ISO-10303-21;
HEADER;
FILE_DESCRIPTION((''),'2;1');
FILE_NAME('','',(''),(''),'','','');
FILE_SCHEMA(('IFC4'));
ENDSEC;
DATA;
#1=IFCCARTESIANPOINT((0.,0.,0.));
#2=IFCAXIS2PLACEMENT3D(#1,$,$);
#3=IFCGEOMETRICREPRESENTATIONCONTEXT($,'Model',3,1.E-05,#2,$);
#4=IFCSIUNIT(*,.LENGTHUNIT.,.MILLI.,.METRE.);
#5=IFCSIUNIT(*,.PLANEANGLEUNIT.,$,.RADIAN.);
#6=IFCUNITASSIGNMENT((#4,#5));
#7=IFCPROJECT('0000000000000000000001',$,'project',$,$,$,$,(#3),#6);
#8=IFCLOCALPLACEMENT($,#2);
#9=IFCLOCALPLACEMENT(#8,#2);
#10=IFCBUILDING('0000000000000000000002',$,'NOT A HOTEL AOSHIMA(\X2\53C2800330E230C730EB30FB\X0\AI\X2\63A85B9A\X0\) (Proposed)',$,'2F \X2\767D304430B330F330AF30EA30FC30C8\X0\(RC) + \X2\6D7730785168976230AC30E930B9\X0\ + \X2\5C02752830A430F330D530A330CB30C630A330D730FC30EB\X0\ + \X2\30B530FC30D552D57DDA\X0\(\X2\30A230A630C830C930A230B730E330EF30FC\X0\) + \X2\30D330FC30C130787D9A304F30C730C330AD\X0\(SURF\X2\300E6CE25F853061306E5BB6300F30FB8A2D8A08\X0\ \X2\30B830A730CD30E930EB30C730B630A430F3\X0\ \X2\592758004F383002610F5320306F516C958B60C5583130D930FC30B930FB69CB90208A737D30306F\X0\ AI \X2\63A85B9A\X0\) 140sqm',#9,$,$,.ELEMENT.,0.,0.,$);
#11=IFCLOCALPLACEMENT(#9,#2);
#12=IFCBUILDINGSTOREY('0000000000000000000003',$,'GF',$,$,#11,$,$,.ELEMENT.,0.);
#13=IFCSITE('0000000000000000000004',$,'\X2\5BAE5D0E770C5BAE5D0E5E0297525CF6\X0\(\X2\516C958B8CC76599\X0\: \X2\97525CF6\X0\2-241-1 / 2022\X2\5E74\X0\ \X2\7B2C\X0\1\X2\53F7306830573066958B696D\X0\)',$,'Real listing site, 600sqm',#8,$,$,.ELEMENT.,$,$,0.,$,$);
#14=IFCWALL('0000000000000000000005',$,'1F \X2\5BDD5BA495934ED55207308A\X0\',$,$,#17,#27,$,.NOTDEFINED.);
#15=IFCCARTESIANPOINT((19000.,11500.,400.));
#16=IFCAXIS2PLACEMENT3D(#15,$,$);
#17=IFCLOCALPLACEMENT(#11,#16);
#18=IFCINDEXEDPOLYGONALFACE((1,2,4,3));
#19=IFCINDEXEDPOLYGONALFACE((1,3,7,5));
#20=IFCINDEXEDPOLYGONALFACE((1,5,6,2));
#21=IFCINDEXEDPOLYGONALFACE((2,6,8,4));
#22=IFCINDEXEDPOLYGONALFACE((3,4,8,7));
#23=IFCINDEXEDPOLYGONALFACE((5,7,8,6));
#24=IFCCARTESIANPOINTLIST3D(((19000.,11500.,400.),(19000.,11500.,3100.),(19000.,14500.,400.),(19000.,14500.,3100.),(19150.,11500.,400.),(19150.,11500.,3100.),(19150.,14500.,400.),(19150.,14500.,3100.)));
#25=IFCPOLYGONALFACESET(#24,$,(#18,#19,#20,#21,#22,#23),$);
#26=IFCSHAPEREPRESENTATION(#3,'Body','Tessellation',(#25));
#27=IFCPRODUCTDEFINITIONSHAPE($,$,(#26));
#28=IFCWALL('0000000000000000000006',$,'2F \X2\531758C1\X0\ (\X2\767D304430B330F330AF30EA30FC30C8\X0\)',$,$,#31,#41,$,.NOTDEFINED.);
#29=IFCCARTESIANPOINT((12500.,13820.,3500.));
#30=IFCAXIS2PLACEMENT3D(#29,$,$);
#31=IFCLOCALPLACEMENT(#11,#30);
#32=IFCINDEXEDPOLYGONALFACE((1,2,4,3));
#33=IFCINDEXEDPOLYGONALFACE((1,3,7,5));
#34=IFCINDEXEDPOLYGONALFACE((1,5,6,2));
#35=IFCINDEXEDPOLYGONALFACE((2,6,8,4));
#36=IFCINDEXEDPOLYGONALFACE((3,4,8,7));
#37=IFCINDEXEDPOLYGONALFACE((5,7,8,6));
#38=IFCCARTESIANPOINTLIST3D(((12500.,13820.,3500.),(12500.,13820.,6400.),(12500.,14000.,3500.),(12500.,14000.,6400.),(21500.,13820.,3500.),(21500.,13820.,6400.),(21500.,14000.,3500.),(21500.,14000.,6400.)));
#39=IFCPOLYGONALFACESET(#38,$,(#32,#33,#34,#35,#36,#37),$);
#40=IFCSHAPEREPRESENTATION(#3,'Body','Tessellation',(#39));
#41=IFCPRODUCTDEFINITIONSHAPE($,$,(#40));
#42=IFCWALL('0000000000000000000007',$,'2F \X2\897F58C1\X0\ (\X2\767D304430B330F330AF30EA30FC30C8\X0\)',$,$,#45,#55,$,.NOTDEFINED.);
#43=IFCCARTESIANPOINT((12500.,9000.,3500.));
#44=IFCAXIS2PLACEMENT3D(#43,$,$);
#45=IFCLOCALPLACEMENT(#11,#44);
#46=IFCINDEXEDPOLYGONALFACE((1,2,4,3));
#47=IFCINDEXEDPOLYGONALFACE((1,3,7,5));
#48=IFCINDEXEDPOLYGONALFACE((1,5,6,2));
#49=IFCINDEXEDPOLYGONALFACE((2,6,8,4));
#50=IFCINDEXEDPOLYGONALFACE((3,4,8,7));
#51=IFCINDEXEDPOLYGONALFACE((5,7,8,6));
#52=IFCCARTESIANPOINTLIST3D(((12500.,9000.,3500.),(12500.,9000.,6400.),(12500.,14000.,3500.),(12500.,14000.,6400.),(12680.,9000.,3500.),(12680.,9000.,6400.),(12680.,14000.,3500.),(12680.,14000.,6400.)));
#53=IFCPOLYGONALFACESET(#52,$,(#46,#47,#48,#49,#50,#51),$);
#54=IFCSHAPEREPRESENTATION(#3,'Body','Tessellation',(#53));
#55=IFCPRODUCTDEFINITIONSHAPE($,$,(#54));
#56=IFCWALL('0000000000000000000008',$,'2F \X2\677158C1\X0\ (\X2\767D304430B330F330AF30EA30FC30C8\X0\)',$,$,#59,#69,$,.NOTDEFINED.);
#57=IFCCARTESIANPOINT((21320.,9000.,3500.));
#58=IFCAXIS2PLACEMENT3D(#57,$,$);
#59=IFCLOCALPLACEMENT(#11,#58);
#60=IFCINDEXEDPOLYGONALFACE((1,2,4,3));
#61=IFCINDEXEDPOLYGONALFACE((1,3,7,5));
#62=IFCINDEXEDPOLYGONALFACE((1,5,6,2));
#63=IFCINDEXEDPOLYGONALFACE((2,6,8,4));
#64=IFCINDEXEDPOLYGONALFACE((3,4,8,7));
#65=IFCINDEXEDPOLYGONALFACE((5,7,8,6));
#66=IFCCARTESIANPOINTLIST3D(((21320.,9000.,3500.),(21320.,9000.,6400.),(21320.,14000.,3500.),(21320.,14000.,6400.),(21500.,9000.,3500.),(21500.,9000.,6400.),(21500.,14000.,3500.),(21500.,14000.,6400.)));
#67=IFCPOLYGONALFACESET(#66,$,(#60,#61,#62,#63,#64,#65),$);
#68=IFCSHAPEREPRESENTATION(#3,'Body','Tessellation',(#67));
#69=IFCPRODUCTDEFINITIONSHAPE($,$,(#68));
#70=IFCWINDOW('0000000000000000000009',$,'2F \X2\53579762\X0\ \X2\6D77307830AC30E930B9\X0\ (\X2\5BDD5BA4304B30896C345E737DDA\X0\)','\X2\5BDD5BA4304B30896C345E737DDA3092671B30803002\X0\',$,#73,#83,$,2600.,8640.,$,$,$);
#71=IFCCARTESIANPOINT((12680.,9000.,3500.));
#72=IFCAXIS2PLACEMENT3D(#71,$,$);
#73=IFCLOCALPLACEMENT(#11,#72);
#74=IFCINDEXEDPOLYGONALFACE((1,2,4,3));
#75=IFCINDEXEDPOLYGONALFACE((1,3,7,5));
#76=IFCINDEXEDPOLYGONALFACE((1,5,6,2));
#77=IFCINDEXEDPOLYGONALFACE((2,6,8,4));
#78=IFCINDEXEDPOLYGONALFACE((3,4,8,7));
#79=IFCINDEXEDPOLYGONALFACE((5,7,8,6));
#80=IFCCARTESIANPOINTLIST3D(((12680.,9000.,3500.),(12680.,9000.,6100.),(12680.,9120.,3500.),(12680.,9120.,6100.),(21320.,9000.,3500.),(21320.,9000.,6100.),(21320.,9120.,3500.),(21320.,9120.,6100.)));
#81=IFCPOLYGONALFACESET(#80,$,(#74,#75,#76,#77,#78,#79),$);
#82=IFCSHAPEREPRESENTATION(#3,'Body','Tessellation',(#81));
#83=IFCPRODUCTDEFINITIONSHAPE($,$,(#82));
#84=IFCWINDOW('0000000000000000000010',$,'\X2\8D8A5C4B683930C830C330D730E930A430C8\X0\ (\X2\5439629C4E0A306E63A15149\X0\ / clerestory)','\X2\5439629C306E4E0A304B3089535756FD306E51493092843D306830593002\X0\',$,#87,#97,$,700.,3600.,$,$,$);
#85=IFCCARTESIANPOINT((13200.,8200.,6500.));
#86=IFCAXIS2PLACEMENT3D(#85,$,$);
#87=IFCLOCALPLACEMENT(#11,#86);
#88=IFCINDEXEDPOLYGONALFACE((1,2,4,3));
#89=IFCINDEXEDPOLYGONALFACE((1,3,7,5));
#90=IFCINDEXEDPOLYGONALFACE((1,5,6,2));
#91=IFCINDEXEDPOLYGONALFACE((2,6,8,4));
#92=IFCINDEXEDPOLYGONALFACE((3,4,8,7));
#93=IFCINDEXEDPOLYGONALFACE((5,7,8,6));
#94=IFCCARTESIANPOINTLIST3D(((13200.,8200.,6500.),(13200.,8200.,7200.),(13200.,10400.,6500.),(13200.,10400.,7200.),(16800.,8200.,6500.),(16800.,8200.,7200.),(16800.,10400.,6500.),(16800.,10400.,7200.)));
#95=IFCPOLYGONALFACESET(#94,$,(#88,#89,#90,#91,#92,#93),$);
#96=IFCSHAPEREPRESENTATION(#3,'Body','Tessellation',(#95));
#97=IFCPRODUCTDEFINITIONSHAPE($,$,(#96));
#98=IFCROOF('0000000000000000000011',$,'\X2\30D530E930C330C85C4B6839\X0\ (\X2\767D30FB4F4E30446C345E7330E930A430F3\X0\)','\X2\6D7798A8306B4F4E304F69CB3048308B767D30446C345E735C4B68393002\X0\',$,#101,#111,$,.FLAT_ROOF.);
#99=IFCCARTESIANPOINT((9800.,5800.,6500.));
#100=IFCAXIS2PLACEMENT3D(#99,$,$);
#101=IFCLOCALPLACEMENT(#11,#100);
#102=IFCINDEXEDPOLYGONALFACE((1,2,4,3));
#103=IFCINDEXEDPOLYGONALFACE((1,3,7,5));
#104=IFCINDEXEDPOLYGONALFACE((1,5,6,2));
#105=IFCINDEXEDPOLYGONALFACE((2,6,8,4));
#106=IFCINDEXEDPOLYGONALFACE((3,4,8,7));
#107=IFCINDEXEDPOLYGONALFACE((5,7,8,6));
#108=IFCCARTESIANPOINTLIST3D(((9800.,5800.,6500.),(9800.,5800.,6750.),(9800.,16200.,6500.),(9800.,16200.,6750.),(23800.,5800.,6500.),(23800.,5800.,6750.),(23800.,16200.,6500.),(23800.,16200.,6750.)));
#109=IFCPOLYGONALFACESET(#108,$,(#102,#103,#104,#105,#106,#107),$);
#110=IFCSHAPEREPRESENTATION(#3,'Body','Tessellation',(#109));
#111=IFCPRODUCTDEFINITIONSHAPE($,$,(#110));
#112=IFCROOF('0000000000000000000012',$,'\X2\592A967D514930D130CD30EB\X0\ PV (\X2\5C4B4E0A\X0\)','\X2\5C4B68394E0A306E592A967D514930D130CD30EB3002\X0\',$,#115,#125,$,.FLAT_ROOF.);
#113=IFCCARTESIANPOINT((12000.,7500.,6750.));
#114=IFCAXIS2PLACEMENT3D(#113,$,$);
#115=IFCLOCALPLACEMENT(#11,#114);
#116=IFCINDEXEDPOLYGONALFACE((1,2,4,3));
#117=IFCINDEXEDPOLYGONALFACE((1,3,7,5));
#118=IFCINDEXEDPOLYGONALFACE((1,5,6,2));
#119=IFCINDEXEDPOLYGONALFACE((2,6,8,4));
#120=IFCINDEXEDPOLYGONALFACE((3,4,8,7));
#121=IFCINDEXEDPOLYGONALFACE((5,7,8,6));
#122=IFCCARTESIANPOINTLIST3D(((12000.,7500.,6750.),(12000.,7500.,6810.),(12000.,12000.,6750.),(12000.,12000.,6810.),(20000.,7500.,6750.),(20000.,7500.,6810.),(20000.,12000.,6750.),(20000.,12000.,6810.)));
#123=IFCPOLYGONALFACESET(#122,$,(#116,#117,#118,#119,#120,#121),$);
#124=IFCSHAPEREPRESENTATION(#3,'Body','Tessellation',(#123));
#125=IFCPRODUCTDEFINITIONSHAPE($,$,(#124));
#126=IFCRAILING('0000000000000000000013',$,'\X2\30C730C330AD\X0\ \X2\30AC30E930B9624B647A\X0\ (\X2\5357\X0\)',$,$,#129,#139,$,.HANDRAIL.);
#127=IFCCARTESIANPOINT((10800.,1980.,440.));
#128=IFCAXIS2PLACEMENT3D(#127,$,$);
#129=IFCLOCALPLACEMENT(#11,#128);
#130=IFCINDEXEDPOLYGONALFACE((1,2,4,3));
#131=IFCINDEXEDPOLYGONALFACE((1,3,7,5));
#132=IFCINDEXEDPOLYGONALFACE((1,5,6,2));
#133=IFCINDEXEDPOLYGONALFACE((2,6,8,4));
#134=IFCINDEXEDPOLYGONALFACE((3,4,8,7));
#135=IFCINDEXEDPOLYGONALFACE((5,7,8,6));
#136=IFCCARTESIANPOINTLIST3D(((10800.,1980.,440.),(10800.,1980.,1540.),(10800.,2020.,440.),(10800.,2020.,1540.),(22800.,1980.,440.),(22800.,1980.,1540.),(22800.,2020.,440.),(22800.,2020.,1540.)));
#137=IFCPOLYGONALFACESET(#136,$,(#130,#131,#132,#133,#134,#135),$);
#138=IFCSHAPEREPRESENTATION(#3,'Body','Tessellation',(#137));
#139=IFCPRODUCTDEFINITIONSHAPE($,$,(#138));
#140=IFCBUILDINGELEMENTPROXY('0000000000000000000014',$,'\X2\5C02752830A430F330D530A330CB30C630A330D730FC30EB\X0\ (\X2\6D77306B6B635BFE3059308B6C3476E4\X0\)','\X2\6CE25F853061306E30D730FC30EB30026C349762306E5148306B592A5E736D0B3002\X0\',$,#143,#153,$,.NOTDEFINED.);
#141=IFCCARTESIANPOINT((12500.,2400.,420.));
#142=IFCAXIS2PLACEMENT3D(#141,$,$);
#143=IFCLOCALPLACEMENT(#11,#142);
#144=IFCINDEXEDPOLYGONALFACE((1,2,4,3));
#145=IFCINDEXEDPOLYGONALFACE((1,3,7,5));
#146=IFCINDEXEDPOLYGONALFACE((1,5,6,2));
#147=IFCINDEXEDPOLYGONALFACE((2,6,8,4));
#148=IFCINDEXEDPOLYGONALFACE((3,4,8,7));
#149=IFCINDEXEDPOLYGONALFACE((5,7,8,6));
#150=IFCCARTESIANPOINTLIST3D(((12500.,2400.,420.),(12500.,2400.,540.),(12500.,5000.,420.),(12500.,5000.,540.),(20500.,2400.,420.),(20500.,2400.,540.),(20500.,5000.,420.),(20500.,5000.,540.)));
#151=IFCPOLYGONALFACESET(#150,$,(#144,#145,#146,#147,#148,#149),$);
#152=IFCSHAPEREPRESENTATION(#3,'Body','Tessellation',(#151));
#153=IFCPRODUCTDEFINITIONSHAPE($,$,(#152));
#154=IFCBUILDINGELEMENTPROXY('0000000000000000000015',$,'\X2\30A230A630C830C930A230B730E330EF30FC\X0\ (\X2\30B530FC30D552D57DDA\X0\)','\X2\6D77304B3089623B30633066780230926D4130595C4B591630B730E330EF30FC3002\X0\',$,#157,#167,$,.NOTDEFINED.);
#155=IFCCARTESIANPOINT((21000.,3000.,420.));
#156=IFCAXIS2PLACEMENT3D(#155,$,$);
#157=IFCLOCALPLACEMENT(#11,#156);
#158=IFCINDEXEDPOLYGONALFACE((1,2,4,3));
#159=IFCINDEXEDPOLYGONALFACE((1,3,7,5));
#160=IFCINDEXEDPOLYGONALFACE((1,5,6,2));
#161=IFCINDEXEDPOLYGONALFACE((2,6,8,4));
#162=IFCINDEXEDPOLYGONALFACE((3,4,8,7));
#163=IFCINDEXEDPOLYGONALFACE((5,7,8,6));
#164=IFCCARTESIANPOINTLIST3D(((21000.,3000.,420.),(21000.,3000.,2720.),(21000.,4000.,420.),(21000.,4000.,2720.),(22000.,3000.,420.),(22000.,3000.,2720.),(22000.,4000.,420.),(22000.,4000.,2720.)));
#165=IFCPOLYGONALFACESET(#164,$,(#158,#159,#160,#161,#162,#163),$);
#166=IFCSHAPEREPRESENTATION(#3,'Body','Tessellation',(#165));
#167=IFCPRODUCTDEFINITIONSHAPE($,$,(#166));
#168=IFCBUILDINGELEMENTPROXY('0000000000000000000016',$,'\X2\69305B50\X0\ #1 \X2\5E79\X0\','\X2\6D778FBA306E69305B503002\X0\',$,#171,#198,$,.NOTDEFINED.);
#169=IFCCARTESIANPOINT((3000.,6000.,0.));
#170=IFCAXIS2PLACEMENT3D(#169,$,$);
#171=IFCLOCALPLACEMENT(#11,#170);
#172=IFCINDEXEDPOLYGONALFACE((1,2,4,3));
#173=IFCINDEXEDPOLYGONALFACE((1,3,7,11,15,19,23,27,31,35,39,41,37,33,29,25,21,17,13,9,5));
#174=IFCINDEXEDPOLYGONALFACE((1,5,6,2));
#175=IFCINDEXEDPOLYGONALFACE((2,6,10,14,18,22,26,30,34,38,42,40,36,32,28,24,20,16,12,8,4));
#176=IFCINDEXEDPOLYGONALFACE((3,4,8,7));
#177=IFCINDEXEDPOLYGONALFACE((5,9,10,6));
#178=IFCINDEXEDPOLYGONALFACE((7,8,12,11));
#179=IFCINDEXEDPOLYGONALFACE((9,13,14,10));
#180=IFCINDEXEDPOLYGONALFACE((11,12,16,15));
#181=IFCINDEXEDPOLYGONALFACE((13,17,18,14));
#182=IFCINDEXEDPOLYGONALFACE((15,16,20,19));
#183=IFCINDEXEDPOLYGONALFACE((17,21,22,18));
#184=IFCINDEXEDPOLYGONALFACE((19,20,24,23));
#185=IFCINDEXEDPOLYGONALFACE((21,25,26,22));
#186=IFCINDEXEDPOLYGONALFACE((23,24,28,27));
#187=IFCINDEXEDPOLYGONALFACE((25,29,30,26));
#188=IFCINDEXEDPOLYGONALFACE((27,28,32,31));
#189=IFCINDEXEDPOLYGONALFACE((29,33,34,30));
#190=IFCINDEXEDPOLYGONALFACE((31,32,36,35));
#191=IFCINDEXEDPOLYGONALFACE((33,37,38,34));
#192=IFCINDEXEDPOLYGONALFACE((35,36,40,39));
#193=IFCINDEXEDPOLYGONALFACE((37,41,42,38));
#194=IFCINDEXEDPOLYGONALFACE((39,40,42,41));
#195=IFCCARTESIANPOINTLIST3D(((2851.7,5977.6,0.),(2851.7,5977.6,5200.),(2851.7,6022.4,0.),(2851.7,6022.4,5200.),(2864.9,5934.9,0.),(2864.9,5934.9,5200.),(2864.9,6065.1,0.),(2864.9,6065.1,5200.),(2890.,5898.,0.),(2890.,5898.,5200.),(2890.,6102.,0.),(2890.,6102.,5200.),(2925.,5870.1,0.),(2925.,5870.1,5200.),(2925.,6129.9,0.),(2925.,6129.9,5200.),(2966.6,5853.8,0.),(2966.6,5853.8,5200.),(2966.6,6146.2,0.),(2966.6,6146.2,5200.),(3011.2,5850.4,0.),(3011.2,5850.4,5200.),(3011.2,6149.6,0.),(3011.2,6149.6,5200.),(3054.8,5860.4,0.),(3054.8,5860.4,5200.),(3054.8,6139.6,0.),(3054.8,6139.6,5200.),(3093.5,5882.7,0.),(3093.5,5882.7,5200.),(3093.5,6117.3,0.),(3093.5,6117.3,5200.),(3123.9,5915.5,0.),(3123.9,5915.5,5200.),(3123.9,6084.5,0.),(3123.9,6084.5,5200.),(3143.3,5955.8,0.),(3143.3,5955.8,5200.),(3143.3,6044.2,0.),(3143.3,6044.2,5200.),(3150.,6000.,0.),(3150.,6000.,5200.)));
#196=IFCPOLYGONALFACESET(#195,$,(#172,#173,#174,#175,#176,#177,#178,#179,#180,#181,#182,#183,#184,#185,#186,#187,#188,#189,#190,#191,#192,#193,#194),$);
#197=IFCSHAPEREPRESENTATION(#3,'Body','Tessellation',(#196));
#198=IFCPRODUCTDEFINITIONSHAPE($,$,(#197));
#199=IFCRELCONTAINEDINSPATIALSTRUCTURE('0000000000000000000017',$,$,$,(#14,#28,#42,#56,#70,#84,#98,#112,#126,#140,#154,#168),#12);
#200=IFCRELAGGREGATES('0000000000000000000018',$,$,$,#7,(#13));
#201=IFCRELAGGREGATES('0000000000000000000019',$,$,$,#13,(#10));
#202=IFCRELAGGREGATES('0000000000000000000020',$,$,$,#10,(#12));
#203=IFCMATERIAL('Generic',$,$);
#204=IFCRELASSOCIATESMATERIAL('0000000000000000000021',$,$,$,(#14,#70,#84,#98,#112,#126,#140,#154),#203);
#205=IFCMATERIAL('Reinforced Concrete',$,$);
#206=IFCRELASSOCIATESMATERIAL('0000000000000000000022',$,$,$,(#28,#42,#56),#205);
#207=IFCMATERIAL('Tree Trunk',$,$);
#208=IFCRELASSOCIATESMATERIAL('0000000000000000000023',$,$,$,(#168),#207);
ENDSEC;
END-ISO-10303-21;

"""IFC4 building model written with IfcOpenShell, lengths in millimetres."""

from ifc_helpers import new_model, si_unit, frame, frame_2d, origin, origin_2d, place, context, project, spatial, rectangle, circle, extrude, material, element, save


model = new_model("IFC4")

# Units and contexts
model_context = context("Model", 3, precision=1e-05, world=origin())
ifc_project = project(units=[si_unit("LENGTHUNIT", "METRE", prefix="MILLI"), si_unit("PLANEANGLEUNIT", "RADIAN")], contexts=[model_context])

# Site, building, storey
site_placement = place(None, origin())
site = spatial("IfcSite", under=ifc_project, at=site_placement, Name="宮崎県宮崎市青島(公開資料: 青島2-241-1 / 2022年 第1号として開業)", ObjectType="Real listing site, 600sqm", CompositionType="ELEMENT", RefElevation=0.0)
building_placement = place(site_placement, origin())
building = spatial("IfcBuilding", under=site, at=building_placement, Name="NOT A HOTEL AOSHIMA(参考モデル・AI推定) (Proposed)", ObjectType="2F 白いコンクリート(RC) + 海へ全面ガラス + 専用インフィニティプール + サーフ動線(アウトドアシャワー) + ビーチへ続くデッキ(SURF『波待ちの家』・設計 ジェネラルデザイン 大堀伸。意匠は公開情報ベース・構造詳細は AI 推定) 140sqm", CompositionType="ELEMENT", ElevationOfRefHeight=0.0, ElevationOfTerrain=0.0)
storey_placement = place(building_placement, origin())
storey = spatial("IfcBuildingStorey", under=building, at=storey_placement, Name="GF", CompositionType="ELEMENT", Elevation=0.0)

# Shared definitions
ifc_material_1 = material(Name="Reinforced Concrete")

# Shared definitions
ifc_material_2 = material(Name="Generic")

# Walls
wall_1_placement = place(storey_placement, frame((19000.0, 11500.0, 400.0)))
element("IfcWall", 1, at=wall_1_placement, inside=storey, material=ifc_material_2, Name="1F 寝室間仕切り", PredefinedType="NOTDEFINED", context=model_context, shape_type="SweptSolid", body=[
    extrude(rectangle(XDim=150.0, YDim=3000.0, at=frame_2d((75.0, 1500.0))), frame((19000.0, 11500.0, 400.0)), (0.0, 0.0, 1.0), 2700.0),
])
wall_2_placement = place(storey_placement, frame((12500.0, 13820.0, 3500.0)))
element("IfcWall", 2, at=wall_2_placement, inside=storey, material=ifc_material_1, Name="2F 北壁 (白いコンクリート)", PredefinedType="NOTDEFINED", context=model_context, shape_type="SweptSolid", body=[
    extrude(rectangle(XDim=9000.0, YDim=180.0, at=frame_2d((4500.0, 90.0))), frame((12500.0, 13820.0, 3500.0)), (0.0, 0.0, 1.0), 2900.0),
])
wall_3_placement = place(storey_placement, frame((12500.0, 9000.0, 3500.0)))
element("IfcWall", 3, at=wall_3_placement, inside=storey, material=ifc_material_1, Name="2F 西壁 (白いコンクリート)", PredefinedType="NOTDEFINED", context=model_context, shape_type="SweptSolid", body=[
    extrude(rectangle(XDim=180.0, YDim=5000.0, at=frame_2d((90.0, 2500.0))), frame((12500.0, 9000.0, 3500.0)), (0.0, 0.0, 1.0), 2900.0),
])
wall_4_placement = place(storey_placement, frame((21320.0, 9000.0, 3500.0)))
element("IfcWall", 4, at=wall_4_placement, inside=storey, material=ifc_material_1, Name="2F 東壁 (白いコンクリート)", PredefinedType="NOTDEFINED", context=model_context, shape_type="SweptSolid", body=[
    extrude(rectangle(XDim=180.0, YDim=5000.0, at=frame_2d((90.0, 2500.0))), frame((21320.0, 9000.0, 3500.0)), (0.0, 0.0, 1.0), 2900.0),
])

# Windows
window_1_placement = place(storey_placement, frame((12680.0, 9000.0, 3500.0)))
element("IfcWindow", 5, at=window_1_placement, inside=storey, material=ifc_material_2, Name="2F 南面 海へガラス (寝室から水平線)", Description="寝室から水平線を望む。", OverallHeight=2600.0, OverallWidth=8640.0, context=model_context, shape_type="SweptSolid", body=[
    extrude(rectangle(XDim=8640.0, YDim=120.0, at=frame_2d((4320.0, 60.0))), frame((12680.0, 9000.0, 3500.0)), (0.0, 0.0, 1.0), 2600.0),
])
window_2_placement = place(storey_placement, frame((13200.0, 8200.0, 6500.0)))
element("IfcWindow", 6, at=window_2_placement, inside=storey, material=ifc_material_2, Name="越屋根トップライト (吹抜上の採光 / clerestory)", Description="吹抜の上から南国の光を落とす。", OverallHeight=700.0, OverallWidth=3600.0, context=model_context, shape_type="SweptSolid", body=[
    extrude(rectangle(XDim=3600.0, YDim=2200.0, at=frame_2d((1800.0, 1100.0))), frame((13200.0, 8200.0, 6500.0)), (0.0, 0.0, 1.0), 700.0),
])

# Roofs
roof_1_placement = place(storey_placement, frame((9800.0, 5800.0, 6500.0)))
element("IfcRoof", 7, at=roof_1_placement, inside=storey, material=ifc_material_2, Name="フラット屋根 (白・低い水平ライン)", Description="海風に低く構える白い水平屋根。", PredefinedType="FLAT_ROOF", context=model_context, shape_type="SweptSolid", body=[
    extrude(rectangle(XDim=14000.0, YDim=10400.0, at=frame_2d((7000.0, 5200.0))), frame((9800.0, 5800.0, 6500.0)), (0.0, 0.0, 1.0), 250.0),
])
roof_2_placement = place(storey_placement, frame((12000.0, 7500.0, 6750.0)))
element("IfcRoof", 8, at=roof_2_placement, inside=storey, material=ifc_material_2, Name="太陽光パネル PV (屋上)", Description="屋根上の太陽光パネル。", PredefinedType="FLAT_ROOF", context=model_context, shape_type="SweptSolid", body=[
    extrude(rectangle(XDim=8000.0, YDim=4500.0, at=frame_2d((4000.0, 2250.0))), frame((12000.0, 7500.0, 6750.0)), (0.0, 0.0, 1.0), 60.0),
])

# Railing
railing_placement = place(storey_placement, frame((10800.0, 1980.0, 440.0)))
element("IfcRailing", 9, at=railing_placement, inside=storey, material=ifc_material_2, Name="デッキ ガラス手摺 (南)", PredefinedType="HANDRAIL", context=model_context, shape_type="SweptSolid", body=[
    extrude(rectangle(XDim=12000.0, YDim=40.0, at=frame_2d((6000.0, 20.0))), frame((10800.0, 1980.0, 440.0)), (0.0, 0.0, 1.0), 1100.0),
])

# Building element proxies
proxy_1_placement = place(storey_placement, frame((12500.0, 2400.0, 420.0)))
element("IfcBuildingElementProxy", 10, at=proxy_1_placement, inside=storey, material=ifc_material_2, Name="専用インフィニティプール (海に正対する水盤)", Description="波待ちのプール。水面の先に太平洋。", PredefinedType="NOTDEFINED", context=model_context, shape_type="SweptSolid", body=[
    extrude(rectangle(XDim=8000.0, YDim=2600.0, at=frame_2d((4000.0, 1300.0))), frame((12500.0, 2400.0, 420.0)), (0.0, 0.0, 1.0), 120.0),
])
proxy_2_placement = place(storey_placement, frame((21000.0, 3000.0, 420.0)))
element("IfcBuildingElementProxy", 11, at=proxy_2_placement, inside=storey, material=ifc_material_2, Name="アウトドアシャワー (サーフ動線)", Description="海から戻って砂を流す屋外シャワー。", PredefinedType="NOTDEFINED", context=model_context, shape_type="SweptSolid", body=[
    extrude(rectangle(XDim=1000.0, YDim=1000.0, at=frame_2d((500.0, 500.0))), frame((21000.0, 3000.0, 420.0)), (0.0, 0.0, 1.0), 2300.0),
])
ifc_material_3 = material(Name="Tree Trunk")
proxy_3_placement = place(storey_placement, frame((3000.0, 6000.0, 0.0)))
element("IfcBuildingElementProxy", 12, at=proxy_3_placement, inside=storey, material=ifc_material_3, Name="椰子 #1 幹", Description="海辺の椰子。", PredefinedType="NOTDEFINED", context=model_context, shape_type="SweptSolid", body=[
    extrude(circle(Radius=150.0, at=origin_2d()), frame((3000.0, 6000.0, 0.0)), (0.0, 0.0, 1.0), 5200.0),
])

save(model, "model.ifc")
